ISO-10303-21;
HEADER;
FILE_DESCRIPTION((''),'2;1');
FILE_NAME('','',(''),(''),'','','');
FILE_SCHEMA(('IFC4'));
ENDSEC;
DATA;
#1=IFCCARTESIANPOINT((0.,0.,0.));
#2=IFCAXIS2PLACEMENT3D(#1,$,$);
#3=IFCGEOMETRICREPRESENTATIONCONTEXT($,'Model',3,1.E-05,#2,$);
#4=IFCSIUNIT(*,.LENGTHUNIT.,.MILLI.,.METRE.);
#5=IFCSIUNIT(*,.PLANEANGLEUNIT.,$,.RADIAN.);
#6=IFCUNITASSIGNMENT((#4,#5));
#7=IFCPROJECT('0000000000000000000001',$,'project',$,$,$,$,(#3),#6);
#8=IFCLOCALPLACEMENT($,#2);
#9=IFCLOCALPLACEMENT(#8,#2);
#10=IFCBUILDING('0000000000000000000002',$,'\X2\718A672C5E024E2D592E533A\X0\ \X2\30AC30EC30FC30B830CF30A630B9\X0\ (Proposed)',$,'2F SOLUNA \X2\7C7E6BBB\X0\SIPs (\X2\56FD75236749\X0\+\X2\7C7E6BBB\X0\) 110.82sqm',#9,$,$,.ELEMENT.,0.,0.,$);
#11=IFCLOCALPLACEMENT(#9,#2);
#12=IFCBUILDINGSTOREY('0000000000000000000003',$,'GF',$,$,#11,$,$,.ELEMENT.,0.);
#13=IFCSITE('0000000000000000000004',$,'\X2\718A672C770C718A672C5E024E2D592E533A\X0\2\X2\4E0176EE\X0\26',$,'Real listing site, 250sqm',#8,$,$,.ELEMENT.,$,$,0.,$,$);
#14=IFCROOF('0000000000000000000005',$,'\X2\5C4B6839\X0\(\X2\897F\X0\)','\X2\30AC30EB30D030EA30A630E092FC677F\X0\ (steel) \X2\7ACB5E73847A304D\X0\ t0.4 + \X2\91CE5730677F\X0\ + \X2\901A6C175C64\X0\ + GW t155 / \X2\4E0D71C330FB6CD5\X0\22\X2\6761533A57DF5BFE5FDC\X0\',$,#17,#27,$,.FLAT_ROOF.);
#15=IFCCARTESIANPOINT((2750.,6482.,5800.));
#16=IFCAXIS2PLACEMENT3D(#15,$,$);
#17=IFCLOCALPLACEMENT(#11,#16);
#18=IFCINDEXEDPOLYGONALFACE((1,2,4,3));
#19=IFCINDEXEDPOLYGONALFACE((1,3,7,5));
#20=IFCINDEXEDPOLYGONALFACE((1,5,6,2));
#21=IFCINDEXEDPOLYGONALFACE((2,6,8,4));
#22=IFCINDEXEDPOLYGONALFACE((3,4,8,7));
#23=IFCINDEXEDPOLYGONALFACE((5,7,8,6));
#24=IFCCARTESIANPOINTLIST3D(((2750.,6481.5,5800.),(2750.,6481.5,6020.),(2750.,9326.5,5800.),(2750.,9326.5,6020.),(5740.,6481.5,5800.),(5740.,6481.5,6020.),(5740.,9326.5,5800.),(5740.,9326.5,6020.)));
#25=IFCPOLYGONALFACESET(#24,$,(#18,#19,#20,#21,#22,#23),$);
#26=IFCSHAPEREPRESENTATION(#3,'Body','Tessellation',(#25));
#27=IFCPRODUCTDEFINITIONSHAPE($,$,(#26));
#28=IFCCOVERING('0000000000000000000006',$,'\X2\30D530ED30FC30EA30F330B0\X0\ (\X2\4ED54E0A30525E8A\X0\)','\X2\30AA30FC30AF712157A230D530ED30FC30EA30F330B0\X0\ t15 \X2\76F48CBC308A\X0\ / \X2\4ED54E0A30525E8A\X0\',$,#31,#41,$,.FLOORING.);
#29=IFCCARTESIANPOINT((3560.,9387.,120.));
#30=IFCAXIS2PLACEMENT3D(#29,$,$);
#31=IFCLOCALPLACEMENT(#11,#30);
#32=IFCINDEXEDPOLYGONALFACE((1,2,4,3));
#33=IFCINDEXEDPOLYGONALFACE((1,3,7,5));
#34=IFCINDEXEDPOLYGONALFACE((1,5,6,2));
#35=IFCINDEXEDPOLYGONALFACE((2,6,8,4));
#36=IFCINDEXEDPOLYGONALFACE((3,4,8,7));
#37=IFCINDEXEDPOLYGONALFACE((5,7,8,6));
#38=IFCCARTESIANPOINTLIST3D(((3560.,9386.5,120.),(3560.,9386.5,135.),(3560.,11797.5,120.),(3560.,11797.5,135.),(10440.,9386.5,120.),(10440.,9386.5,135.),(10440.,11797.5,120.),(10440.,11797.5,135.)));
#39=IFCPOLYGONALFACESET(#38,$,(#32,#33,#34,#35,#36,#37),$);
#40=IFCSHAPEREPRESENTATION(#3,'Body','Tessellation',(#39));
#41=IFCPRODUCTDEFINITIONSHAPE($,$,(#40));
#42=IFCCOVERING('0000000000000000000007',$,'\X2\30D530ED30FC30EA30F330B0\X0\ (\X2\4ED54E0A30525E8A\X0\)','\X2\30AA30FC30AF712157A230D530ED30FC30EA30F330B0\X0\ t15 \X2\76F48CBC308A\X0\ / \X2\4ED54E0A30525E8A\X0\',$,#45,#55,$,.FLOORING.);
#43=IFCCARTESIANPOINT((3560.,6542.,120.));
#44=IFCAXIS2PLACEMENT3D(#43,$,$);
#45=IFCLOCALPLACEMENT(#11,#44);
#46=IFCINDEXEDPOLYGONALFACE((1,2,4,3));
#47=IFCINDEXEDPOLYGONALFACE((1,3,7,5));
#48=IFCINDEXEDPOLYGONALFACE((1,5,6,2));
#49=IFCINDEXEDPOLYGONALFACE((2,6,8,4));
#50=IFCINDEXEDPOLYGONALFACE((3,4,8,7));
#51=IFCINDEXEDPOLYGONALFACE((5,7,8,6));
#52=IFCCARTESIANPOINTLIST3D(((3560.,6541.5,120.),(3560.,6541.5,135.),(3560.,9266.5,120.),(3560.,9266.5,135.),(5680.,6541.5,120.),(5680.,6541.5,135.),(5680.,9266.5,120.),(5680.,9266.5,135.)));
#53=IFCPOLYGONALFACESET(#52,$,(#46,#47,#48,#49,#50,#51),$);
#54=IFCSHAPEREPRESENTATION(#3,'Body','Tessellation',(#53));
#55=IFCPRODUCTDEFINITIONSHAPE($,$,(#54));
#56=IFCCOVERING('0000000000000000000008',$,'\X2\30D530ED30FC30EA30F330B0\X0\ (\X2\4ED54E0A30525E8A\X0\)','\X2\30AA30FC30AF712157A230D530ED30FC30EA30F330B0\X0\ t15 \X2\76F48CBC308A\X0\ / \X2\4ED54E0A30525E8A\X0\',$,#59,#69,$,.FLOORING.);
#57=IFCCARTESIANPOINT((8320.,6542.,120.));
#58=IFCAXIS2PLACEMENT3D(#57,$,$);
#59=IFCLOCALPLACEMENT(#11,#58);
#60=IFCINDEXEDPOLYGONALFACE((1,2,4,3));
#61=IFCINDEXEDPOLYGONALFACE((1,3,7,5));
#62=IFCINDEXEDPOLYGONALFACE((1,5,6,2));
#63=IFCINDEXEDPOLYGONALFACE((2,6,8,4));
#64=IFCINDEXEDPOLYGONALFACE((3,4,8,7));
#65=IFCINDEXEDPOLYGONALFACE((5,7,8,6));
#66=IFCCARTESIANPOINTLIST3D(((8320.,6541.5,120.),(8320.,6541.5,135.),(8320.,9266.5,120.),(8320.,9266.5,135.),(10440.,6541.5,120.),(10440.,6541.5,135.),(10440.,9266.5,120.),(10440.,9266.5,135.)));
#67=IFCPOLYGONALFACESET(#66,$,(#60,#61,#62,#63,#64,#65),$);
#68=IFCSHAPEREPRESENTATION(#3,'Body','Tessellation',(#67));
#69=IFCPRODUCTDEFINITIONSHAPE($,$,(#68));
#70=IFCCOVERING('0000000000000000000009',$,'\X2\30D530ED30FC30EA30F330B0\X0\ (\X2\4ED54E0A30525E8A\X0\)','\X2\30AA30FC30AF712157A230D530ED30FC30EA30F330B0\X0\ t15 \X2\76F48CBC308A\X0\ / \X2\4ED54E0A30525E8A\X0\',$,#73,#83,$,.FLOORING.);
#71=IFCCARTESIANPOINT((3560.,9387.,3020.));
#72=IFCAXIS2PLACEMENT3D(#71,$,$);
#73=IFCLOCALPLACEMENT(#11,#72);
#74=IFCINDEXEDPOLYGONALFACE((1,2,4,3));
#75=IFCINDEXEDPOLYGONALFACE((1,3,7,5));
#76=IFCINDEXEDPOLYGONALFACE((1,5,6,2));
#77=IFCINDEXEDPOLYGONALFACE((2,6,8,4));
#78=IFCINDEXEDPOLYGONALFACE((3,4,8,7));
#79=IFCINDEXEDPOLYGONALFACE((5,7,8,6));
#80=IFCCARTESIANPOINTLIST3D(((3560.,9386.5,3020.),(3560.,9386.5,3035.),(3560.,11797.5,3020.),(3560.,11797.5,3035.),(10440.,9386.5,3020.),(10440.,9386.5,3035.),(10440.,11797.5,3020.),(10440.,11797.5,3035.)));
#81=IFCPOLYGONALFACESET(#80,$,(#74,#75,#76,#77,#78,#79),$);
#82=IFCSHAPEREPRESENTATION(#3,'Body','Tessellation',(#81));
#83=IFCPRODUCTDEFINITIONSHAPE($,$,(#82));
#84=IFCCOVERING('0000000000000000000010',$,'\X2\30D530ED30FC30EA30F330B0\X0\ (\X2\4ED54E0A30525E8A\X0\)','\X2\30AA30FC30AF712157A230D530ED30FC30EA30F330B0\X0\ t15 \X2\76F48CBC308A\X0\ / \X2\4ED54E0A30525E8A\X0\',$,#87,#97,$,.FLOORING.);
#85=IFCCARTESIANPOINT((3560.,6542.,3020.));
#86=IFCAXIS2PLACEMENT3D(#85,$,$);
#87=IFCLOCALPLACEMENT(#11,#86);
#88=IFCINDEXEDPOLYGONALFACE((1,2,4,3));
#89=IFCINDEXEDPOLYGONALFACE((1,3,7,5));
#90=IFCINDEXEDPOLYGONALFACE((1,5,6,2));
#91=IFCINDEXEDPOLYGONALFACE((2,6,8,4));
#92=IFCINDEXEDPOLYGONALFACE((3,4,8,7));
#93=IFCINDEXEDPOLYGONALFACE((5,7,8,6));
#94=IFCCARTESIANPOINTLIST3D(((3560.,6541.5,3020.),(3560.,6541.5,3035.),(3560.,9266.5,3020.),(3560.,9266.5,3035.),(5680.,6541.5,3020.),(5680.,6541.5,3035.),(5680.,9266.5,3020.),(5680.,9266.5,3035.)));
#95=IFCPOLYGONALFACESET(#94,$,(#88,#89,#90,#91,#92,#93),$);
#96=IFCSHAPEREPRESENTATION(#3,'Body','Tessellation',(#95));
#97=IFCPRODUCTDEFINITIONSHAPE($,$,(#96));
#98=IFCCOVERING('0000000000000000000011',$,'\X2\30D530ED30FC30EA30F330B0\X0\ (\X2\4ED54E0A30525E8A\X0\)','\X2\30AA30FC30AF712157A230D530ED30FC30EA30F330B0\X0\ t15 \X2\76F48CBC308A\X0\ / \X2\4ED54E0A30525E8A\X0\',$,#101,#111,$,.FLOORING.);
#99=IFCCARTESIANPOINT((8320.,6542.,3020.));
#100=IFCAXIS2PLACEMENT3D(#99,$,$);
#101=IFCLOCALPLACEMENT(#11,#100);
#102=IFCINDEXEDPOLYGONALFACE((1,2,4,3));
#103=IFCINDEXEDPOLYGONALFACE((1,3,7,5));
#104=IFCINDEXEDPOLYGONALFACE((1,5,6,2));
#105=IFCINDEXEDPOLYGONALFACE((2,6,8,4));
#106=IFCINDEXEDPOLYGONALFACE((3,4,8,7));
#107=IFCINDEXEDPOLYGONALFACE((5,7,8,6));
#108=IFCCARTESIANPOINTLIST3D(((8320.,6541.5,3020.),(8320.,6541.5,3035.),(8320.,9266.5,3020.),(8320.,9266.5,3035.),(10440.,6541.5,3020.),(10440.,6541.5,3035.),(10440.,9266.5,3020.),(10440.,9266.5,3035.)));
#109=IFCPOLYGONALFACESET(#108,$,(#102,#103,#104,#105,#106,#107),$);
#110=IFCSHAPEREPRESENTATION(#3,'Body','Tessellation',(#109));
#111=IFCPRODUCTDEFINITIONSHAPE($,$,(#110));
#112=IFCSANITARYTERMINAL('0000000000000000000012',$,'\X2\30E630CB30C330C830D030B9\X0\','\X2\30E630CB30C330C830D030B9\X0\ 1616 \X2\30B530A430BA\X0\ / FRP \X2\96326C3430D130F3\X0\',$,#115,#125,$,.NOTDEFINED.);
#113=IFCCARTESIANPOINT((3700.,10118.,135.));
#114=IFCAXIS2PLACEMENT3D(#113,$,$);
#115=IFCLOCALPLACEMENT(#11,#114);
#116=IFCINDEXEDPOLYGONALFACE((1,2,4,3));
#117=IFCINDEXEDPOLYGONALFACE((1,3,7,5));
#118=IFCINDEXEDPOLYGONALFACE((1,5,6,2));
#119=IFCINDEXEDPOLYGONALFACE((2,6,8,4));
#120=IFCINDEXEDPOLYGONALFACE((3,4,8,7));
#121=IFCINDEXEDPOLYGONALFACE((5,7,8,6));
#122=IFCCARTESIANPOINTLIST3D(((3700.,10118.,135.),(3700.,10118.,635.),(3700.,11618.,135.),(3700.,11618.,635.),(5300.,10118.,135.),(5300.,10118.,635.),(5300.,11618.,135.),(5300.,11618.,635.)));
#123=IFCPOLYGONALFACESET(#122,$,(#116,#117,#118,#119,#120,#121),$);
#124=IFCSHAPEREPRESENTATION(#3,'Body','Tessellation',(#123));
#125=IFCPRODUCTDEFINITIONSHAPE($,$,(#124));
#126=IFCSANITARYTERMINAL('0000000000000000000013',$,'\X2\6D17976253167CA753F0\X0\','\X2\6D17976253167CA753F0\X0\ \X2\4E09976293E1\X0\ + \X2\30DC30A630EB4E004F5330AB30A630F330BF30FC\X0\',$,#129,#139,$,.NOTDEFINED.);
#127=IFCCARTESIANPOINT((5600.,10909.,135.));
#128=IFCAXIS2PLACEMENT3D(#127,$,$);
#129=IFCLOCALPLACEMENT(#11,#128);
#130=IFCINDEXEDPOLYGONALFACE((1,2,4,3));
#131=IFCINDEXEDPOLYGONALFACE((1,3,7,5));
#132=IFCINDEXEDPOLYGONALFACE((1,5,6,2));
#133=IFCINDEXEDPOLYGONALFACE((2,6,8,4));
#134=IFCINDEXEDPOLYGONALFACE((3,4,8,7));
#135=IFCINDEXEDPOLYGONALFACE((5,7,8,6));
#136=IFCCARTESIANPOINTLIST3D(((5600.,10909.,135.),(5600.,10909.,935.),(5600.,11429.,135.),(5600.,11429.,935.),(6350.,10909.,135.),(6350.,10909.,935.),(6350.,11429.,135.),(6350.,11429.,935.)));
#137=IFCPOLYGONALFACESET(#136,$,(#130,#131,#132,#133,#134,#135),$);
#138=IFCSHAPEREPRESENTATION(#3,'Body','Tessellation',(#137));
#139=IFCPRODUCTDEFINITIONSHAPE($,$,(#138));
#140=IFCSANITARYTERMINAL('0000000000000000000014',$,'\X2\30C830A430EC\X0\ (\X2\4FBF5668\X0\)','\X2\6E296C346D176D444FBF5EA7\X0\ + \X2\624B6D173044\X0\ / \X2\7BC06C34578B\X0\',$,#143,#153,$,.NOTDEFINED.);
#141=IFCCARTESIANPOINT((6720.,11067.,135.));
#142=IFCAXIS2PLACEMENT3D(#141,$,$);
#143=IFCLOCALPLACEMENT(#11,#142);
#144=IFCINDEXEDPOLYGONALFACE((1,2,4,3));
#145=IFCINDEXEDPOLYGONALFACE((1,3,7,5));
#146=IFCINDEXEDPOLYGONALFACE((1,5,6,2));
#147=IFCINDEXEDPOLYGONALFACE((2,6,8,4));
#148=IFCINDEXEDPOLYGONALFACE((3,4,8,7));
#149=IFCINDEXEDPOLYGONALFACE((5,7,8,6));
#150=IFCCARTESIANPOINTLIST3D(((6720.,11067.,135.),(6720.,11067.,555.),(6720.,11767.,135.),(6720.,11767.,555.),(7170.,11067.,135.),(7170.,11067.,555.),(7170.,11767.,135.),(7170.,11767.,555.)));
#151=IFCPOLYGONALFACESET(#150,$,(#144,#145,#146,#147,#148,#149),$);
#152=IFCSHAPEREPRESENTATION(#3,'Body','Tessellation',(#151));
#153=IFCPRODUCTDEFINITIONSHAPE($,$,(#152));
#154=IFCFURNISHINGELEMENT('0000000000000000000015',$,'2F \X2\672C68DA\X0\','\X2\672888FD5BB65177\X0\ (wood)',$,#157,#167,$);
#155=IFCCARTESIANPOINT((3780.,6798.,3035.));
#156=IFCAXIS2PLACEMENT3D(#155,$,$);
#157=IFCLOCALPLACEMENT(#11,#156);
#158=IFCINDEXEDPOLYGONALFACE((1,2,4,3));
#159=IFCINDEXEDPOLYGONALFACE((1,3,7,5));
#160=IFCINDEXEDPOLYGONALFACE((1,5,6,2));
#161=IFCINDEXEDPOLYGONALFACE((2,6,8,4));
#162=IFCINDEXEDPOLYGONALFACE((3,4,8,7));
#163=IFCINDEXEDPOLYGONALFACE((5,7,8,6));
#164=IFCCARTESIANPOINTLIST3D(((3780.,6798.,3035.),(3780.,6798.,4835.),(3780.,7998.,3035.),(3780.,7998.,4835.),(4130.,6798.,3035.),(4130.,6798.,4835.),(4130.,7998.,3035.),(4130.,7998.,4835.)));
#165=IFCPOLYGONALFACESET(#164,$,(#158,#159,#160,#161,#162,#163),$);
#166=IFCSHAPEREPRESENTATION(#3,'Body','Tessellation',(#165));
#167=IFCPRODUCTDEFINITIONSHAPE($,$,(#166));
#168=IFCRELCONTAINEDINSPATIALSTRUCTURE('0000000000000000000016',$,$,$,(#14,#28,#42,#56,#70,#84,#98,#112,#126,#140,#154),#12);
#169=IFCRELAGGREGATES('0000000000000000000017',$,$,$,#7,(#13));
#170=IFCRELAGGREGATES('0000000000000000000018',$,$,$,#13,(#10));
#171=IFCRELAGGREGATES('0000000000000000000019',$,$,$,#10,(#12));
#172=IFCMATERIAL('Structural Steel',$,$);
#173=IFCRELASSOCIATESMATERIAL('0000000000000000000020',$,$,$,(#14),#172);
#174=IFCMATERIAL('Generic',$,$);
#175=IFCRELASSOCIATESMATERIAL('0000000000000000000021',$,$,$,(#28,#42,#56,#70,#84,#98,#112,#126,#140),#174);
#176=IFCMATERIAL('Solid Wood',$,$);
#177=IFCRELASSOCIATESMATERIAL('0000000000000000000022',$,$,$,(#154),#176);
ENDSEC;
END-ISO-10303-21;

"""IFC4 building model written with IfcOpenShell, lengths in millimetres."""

from ifc_helpers import new_model, si_unit, frame, frame_2d, origin, place, context, project, spatial, rectangle, extrude, material, element, save


model = new_model("IFC4")

# Units and contexts
model_context = context("Model", 3, precision=1e-05, world=origin())
ifc_project = project(units=[si_unit("LENGTHUNIT", "METRE", prefix="MILLI"), si_unit("PLANEANGLEUNIT", "RADIAN")], contexts=[model_context])

# Site, building, storey
site_placement = place(None, origin())
site = spatial("IfcSite", under=ifc_project, at=site_placement, Name="熊本県熊本市中央区2丁目26", ObjectType="Real listing site, 250sqm", CompositionType="ELEMENT", RefElevation=0.0)
building_placement = place(site_placement, origin())
building = spatial("IfcBuilding", under=site, at=building_placement, Name="熊本市中央区 ガレージハウス (Proposed)", ObjectType="2F SOLUNA 籾殻SIPs (国産杉+籾殻) 110.82sqm", CompositionType="ELEMENT", ElevationOfRefHeight=0.0, ElevationOfTerrain=0.0)
storey_placement = place(building_placement, origin())
storey = spatial("IfcBuildingStorey", under=building, at=storey_placement, Name="GF", CompositionType="ELEMENT", Elevation=0.0)

# Shared definitions
ifc_material_1 = material(Name="Solid Wood")

# Shared definitions
ifc_material_2 = material(Name="Generic")

# Roof
ifc_material_3 = material(Name="Structural Steel")
roof_1_placement = place(storey_placement, frame((2750.0, 6482.0, 5800.0)))
element("IfcRoof", 1, at=roof_1_placement, inside=storey, material=ifc_material_3, Name="屋根(西)", Description="ガルバリウム鋼板 (steel) 立平葺き t0.4 + 野地板 + 通気層 + GW t155 / 不燃・法22条区域対応", PredefinedType="FLAT_ROOF", context=model_context, shape_type="SweptSolid", body=[
    extrude(rectangle(XDim=2990.0, YDim=2845.0, at=frame_2d((1495.0, 1422.0))), frame((2750.0, 6482.0, 5800.0)), (0.0, 0.0, 1.0), 220.0),
])

# Coverings
covering_1_placement = place(storey_placement, frame((3560.0, 9387.0, 120.0)))
element("IfcCovering", 2, at=covering_1_placement, inside=storey, material=ifc_material_2, Name="フローリング (仕上げ床)", Description="オーク無垢フローリング t15 直貼り / 仕上げ床", PredefinedType="FLOORING", context=model_context, shape_type="SweptSolid", body=[
    extrude(rectangle(XDim=6880.0, YDim=2411.0, at=frame_2d((3440.0, 1205.0))), frame((3560.0, 9387.0, 120.0)), (0.0, 0.0, 1.0), 15.0),
])
covering_2_placement = place(storey_placement, frame((3560.0, 6542.0, 120.0)))
element("IfcCovering", 3, at=covering_2_placement, inside=storey, material=ifc_material_2, Name="フローリング (仕上げ床)", Description="オーク無垢フローリング t15 直貼り / 仕上げ床", PredefinedType="FLOORING", context=model_context, shape_type="SweptSolid", body=[
    extrude(rectangle(XDim=2120.0, YDim=2725.0, at=frame_2d((1060.0, 1362.0))), frame((3560.0, 6542.0, 120.0)), (0.0, 0.0, 1.0), 15.0),
])
covering_3_placement = place(storey_placement, frame((8320.0, 6542.0, 120.0)))
element("IfcCovering", 4, at=covering_3_placement, inside=storey, material=ifc_material_2, Name="フローリング (仕上げ床)", Description="オーク無垢フローリング t15 直貼り / 仕上げ床", PredefinedType="FLOORING", context=model_context, shape_type="SweptSolid", body=[
    extrude(rectangle(XDim=2120.0, YDim=2725.0, at=frame_2d((1060.0, 1362.0))), frame((8320.0, 6542.0, 120.0)), (0.0, 0.0, 1.0), 15.0),
])
covering_4_placement = place(storey_placement, frame((3560.0, 9387.0, 3020.0)))
element("IfcCovering", 5, at=covering_4_placement, inside=storey, material=ifc_material_2, Name="フローリング (仕上げ床)", Description="オーク無垢フローリング t15 直貼り / 仕上げ床", PredefinedType="FLOORING", context=model_context, shape_type="SweptSolid", body=[
    extrude(rectangle(XDim=6880.0, YDim=2411.0, at=frame_2d((3440.0, 1205.0))), frame((3560.0, 9387.0, 3020.0)), (0.0, 0.0, 1.0), 15.0),
])
covering_5_placement = place(storey_placement, frame((3560.0, 6542.0, 3020.0)))
element("IfcCovering", 6, at=covering_5_placement, inside=storey, material=ifc_material_2, Name="フローリング (仕上げ床)", Description="オーク無垢フローリング t15 直貼り / 仕上げ床", PredefinedType="FLOORING", context=model_context, shape_type="SweptSolid", body=[
    extrude(rectangle(XDim=2120.0, YDim=2725.0, at=frame_2d((1060.0, 1362.0))), frame((3560.0, 6542.0, 3020.0)), (0.0, 0.0, 1.0), 15.0),
])
covering_6_placement = place(storey_placement, frame((8320.0, 6542.0, 3020.0)))
element("IfcCovering", 7, at=covering_6_placement, inside=storey, material=ifc_material_2, Name="フローリング (仕上げ床)", Description="オーク無垢フローリング t15 直貼り / 仕上げ床", PredefinedType="FLOORING", context=model_context, shape_type="SweptSolid", body=[
    extrude(rectangle(XDim=2120.0, YDim=2725.0, at=frame_2d((1060.0, 1362.0))), frame((8320.0, 6542.0, 3020.0)), (0.0, 0.0, 1.0), 15.0),
])

# Sanitary terminals
sanitary_terminal_1_placement = place(storey_placement, frame((3700.0, 10118.0, 135.0)))
element("IfcSanitaryTerminal", 8, at=sanitary_terminal_1_placement, inside=storey, material=ifc_material_2, Name="ユニットバス", Description="ユニットバス 1616 サイズ / FRP 防水パン", PredefinedType="NOTDEFINED", context=model_context, shape_type="SweptSolid", body=[
    extrude(rectangle(XDim=1600.0, YDim=1500.0, at=frame_2d((800.0, 750.0))), frame((3700.0, 10118.0, 135.0)), (0.0, 0.0, 1.0), 500.0),
])
sanitary_terminal_2_placement = place(storey_placement, frame((5600.0, 10909.0, 135.0)))
element("IfcSanitaryTerminal", 9, at=sanitary_terminal_2_placement, inside=storey, material=ifc_material_2, Name="洗面化粧台", Description="洗面化粧台 三面鏡 + ボウル一体カウンター", PredefinedType="NOTDEFINED", context=model_context, shape_type="SweptSolid", body=[
    extrude(rectangle(XDim=750.0, YDim=520.0, at=frame_2d((375.0, 260.0))), frame((5600.0, 10909.0, 135.0)), (0.0, 0.0, 1.0), 800.0),
])
sanitary_terminal_3_placement = place(storey_placement, frame((6720.0, 11067.0, 135.0)))
element("IfcSanitaryTerminal", 10, at=sanitary_terminal_3_placement, inside=storey, material=ifc_material_2, Name="トイレ (便器)", Description="温水洗浄便座 + 手洗い / 節水型", PredefinedType="NOTDEFINED", context=model_context, shape_type="SweptSolid", body=[
    extrude(rectangle(XDim=450.0, YDim=700.0, at=frame_2d((225.0, 350.0))), frame((6720.0, 11067.0, 135.0)), (0.0, 0.0, 1.0), 420.0),
])

# Furnishing element
furnishing_placement = place(storey_placement, frame((3780.0, 6798.0, 3035.0)))
element("IfcFurnishingElement", 11, at=furnishing_placement, inside=storey, material=ifc_material_1, Name="2F 本棚", Description="木製家具 (wood)", context=model_context, shape_type="SweptSolid", body=[
    extrude(rectangle(XDim=350.0, YDim=1200.0, at=frame_2d((175.0, 600.0))), frame((3780.0, 6798.0, 3035.0)), (0.0, 0.0, 1.0), 1800.0),
])

save(model, "model.ifc")
